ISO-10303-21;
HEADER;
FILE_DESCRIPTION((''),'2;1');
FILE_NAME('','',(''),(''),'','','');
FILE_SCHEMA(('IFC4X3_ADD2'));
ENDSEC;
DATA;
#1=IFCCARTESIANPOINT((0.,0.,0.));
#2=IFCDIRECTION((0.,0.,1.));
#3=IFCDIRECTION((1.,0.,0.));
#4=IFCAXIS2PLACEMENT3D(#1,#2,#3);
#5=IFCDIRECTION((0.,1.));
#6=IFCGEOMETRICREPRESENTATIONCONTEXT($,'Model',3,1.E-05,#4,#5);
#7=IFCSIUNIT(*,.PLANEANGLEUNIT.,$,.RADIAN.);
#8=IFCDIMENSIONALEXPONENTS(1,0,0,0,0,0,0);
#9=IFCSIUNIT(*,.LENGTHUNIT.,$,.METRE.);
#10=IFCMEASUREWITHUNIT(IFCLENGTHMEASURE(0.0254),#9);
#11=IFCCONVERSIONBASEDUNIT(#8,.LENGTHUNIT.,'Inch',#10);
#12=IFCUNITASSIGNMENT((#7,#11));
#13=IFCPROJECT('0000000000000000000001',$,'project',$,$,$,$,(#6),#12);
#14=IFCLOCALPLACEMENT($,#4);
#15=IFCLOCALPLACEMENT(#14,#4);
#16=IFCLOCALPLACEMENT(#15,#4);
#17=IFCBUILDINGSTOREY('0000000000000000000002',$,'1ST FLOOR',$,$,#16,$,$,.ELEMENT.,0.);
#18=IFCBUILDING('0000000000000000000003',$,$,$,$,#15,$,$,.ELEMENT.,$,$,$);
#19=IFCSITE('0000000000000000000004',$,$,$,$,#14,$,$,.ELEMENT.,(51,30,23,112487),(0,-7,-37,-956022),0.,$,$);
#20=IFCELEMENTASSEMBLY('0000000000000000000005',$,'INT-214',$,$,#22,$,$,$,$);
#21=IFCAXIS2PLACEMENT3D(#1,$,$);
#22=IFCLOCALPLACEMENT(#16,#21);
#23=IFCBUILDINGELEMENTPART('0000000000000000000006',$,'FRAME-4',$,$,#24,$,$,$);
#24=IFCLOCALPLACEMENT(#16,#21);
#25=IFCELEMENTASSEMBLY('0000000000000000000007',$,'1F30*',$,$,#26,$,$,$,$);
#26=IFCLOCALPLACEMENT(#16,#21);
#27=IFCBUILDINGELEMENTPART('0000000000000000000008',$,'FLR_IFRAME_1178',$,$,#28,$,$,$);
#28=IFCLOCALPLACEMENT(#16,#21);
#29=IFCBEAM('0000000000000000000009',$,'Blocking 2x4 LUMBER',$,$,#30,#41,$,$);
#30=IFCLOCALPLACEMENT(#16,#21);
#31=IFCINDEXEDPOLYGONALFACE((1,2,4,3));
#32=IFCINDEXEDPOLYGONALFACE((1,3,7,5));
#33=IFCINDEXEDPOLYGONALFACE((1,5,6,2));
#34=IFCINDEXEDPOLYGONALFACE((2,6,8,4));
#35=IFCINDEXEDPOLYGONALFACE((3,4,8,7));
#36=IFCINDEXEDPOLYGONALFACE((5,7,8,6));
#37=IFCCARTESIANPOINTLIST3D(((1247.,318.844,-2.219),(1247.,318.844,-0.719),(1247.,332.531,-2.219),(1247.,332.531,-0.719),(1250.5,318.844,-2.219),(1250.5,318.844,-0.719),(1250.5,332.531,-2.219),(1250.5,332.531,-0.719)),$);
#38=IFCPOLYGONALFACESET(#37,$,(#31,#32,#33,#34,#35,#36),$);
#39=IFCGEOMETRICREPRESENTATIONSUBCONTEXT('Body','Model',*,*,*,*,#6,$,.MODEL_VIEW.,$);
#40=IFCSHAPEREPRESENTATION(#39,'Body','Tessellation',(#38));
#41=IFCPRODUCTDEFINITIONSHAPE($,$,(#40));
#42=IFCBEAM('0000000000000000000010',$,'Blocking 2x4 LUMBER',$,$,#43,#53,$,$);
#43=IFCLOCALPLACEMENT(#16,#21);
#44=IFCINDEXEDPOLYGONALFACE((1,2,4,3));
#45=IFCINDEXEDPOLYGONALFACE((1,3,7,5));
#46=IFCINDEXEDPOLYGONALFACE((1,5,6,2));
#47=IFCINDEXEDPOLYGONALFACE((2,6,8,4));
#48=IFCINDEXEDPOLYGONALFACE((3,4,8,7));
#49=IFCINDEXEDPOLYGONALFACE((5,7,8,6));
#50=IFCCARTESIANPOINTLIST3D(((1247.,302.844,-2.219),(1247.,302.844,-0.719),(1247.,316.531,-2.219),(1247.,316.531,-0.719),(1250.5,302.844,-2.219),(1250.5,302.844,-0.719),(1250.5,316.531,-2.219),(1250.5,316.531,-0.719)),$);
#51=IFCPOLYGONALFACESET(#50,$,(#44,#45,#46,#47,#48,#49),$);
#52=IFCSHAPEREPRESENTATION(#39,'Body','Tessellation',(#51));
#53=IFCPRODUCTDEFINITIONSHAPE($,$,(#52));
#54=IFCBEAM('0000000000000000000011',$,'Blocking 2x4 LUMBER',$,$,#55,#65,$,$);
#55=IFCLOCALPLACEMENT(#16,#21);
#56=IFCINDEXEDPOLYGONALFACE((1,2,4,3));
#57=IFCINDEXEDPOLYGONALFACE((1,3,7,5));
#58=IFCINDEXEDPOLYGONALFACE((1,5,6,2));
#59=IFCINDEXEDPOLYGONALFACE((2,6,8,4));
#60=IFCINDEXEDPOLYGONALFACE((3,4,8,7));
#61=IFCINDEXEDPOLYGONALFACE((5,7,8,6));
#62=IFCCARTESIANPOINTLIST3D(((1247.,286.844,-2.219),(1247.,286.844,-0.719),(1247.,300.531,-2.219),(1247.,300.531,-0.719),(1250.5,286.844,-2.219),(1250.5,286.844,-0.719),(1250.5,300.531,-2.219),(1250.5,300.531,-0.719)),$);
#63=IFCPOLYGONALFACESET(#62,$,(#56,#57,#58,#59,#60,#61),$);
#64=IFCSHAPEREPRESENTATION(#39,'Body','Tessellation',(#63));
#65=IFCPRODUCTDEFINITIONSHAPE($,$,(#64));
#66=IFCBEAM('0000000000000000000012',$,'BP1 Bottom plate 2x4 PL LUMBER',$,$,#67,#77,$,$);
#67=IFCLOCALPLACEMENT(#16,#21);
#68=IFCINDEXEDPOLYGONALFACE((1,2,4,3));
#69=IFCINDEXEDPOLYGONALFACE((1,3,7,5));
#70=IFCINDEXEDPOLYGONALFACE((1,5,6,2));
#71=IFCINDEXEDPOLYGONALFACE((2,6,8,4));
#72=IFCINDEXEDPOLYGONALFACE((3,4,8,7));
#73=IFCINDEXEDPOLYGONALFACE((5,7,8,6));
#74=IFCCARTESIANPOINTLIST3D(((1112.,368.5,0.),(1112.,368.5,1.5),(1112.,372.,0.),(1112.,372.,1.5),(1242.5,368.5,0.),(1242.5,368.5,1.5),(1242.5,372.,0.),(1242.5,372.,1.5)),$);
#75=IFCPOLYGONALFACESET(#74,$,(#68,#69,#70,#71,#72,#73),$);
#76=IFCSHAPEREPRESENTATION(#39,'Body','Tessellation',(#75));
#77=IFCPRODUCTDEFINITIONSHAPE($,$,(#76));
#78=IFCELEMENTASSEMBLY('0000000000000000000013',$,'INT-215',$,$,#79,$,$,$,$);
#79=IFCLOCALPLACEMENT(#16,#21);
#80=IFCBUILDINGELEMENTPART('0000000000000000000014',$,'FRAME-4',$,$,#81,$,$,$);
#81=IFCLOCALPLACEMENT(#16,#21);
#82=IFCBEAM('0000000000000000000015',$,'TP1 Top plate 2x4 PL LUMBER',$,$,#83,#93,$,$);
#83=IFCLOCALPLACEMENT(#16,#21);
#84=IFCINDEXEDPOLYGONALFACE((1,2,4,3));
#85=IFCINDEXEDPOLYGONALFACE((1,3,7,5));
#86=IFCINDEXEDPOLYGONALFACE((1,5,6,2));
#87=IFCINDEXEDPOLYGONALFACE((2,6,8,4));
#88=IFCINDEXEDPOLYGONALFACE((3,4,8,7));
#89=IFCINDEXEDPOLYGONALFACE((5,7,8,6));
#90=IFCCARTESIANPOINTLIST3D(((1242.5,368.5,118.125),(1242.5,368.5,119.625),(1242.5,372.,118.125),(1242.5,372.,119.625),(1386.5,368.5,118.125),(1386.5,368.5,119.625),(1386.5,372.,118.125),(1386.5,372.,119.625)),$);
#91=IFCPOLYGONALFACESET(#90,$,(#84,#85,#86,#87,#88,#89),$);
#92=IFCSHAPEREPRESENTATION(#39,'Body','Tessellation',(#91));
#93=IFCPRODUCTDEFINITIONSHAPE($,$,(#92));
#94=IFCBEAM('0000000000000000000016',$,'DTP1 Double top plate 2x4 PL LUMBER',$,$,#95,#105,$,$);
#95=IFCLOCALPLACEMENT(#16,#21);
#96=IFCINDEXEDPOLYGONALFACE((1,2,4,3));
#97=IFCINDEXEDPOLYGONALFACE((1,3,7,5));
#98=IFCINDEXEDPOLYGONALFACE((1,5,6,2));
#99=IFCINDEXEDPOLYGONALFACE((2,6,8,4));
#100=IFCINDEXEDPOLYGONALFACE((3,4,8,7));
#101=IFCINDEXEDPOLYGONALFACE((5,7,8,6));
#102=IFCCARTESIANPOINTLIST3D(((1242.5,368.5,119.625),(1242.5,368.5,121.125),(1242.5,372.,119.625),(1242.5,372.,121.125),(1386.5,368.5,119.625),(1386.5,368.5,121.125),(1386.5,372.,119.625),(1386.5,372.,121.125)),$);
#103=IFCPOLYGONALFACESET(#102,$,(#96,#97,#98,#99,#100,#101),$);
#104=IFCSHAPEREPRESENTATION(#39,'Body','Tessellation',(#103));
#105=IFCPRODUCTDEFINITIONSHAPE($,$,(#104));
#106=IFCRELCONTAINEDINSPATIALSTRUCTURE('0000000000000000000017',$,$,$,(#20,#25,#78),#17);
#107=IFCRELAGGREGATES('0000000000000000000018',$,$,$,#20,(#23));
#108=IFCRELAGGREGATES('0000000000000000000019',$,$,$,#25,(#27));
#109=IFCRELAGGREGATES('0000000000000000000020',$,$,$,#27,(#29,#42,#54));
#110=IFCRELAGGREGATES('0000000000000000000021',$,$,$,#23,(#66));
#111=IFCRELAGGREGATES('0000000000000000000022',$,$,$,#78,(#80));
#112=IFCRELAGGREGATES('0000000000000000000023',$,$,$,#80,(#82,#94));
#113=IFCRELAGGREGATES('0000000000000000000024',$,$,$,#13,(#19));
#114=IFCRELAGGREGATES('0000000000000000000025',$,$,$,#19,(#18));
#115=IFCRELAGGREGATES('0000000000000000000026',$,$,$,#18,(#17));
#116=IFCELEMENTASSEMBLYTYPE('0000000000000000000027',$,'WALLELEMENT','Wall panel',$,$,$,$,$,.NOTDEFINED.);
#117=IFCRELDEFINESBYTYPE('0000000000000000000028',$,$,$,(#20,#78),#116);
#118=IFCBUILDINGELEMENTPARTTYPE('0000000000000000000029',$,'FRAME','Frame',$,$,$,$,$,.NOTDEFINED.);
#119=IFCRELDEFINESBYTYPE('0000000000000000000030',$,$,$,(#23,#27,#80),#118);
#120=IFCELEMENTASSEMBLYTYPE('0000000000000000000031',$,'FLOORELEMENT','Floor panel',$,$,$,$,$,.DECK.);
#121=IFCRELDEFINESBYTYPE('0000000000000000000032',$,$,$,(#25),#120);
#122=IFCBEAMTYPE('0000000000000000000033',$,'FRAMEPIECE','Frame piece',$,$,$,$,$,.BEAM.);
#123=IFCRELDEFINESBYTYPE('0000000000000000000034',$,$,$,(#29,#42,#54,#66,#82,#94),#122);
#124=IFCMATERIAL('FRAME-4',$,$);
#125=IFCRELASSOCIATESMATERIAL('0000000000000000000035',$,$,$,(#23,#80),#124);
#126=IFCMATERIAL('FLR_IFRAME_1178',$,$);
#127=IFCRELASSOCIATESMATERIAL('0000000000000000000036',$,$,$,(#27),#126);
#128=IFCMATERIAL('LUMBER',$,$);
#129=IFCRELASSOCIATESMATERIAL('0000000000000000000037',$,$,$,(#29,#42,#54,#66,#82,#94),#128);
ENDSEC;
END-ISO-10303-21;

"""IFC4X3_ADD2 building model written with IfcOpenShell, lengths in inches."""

from ifc_helpers import new_model, entity, si_unit, converted_unit, direction, frame, origin_with_axes, origin_2d_with_axis, place, context, subcontext, project, spatial, rectangle, extrude, material, type_object, element, aggregate, save


model = new_model("IFC4X3_ADD2")

# Units and contexts
model_context = context("Model", 3, precision=1e-05, world=origin_with_axes(), true_north=direction((0.0, 1.0)))
body_context = subcontext(model_context, "Body", "Model", "MODEL_VIEW")
ifc_project = project(units=[si_unit("PLANEANGLEUNIT", "RADIAN"), converted_unit("LENGTHUNIT", "Inch", entity("IfcLengthMeasure", 0.0254), si_unit("LENGTHUNIT", "METRE"), dimensions=[1, 0, 0, 0, 0, 0, 0])], contexts=[model_context])

# Site, building, storey
site_placement = place(None, origin_with_axes())
site = spatial("IfcSite", under=ifc_project, at=site_placement, CompositionType="ELEMENT", RefLatitude=(51, 30, 23, 112487), RefLongitude=(0, -7, -37, -956022), RefElevation=0.0)
building_placement = place(site_placement, origin_with_axes())
building = spatial("IfcBuilding", under=site, at=building_placement, CompositionType="ELEMENT")
storey_placement = place(building_placement, origin_with_axes())
storey = spatial("IfcBuildingStorey", under=building, at=storey_placement, Name="1ST FLOOR", CompositionType="ELEMENT", Elevation=0.0)

# Element assembly, building element part
element_assembly_type_1 = type_object("IfcElementAssemblyType", Name="WALLELEMENT", Description="Wall panel", PredefinedType="NOTDEFINED")
assembly_1_placement = place(storey_placement, origin_with_axes())
assembly_1 = element("IfcElementAssembly", 1, at=assembly_1_placement, inside=storey, type_object=element_assembly_type_1, Name="INT-214")
ifc_material_1 = material(Name="FRAME-4")
building_element_part_type = type_object("IfcBuildingElementPartType", Name="FRAME", Description="Frame", PredefinedType="NOTDEFINED")
building_element_part_1_placement = place(storey_placement, origin_with_axes())
building_element_part_1 = element("IfcBuildingElementPart", 2, at=building_element_part_1_placement, type_object=building_element_part_type, material=ifc_material_1, Name="FRAME-4")
aggregate(assembly_1, [building_element_part_1])
ifc_material_2 = material(Name="LUMBER")

# Element assembly, building element part, beams
element_assembly_type_2 = type_object("IfcElementAssemblyType", Name="FLOORELEMENT", Description="Floor panel", PredefinedType="DECK")
ifc_material_3 = material(Name="FLR_IFRAME_1178")
beam_type = type_object("IfcBeamType", Name="FRAMEPIECE", Description="Frame piece", PredefinedType="BEAM")
assembly_2_placement = place(storey_placement, origin_with_axes())
assembly_2 = element("IfcElementAssembly", 3, at=assembly_2_placement, inside=storey, type_object=element_assembly_type_2, Name="1F30*")
building_element_part_2_placement = place(storey_placement, origin_with_axes())
building_element_part_2 = element("IfcBuildingElementPart", 4, at=building_element_part_2_placement, type_object=building_element_part_type, material=ifc_material_3, Name="FLR_IFRAME_1178")
aggregate(assembly_2, [building_element_part_2])
beam_1_placement = place(storey_placement, frame((1248.75, 332.531, -1.469), z_axis=(0.0, -1.0, 0.0), x_axis=(0.0, 0.0, 1.0)))
beam_1 = element("IfcBeam", 5, at=beam_1_placement, type_object=beam_type, material=ifc_material_2, Name="Blocking 2x4 LUMBER", context=body_context, shape_type="SweptSolid", body=[
    extrude(rectangle(XDim=1.5, YDim=3.5, at=origin_2d_with_axis()), origin_with_axes(), (0.0, 0.0, 1.0), 13.688),
])
beam_2_placement = place(storey_placement, frame((1248.75, 316.531, -1.469), z_axis=(0.0, -1.0, 0.0), x_axis=(0.0, 0.0, 1.0)))
beam_2 = element("IfcBeam", 6, at=beam_2_placement, type_object=beam_type, material=ifc_material_2, Name="Blocking 2x4 LUMBER", context=body_context, shape_type="SweptSolid", body=[
    extrude(rectangle(XDim=1.5, YDim=3.5, at=origin_2d_with_axis()), origin_with_axes(), (0.0, 0.0, 1.0), 13.688),
])
beam_3_placement = place(storey_placement, frame((1248.75, 300.531, -1.469), z_axis=(0.0, -1.0, 0.0), x_axis=(0.0, 0.0, 1.0)))
beam_3 = element("IfcBeam", 7, at=beam_3_placement, type_object=beam_type, material=ifc_material_2, Name="Blocking 2x4 LUMBER", context=body_context, shape_type="SweptSolid", body=[
    extrude(rectangle(XDim=1.5, YDim=3.5, at=origin_2d_with_axis()), origin_with_axes(), (0.0, 0.0, 1.0), 13.688),
])
aggregate(building_element_part_2, [beam_1, beam_2, beam_3])

# Beam
beam_4_placement = place(storey_placement, frame((1242.5, 370.25, 0.75), z_axis=(-1.0, 0.0, 0.0), x_axis=(0.0, 0.0, 1.0)))
beam_4 = element("IfcBeam", 8, at=beam_4_placement, type_object=beam_type, material=ifc_material_2, Name="BP1 Bottom plate 2x4 PL LUMBER", context=body_context, shape_type="SweptSolid", body=[
    extrude(rectangle(XDim=1.5, YDim=3.5, at=origin_2d_with_axis()), origin_with_axes(), (0.0, 0.0, 1.0), 130.5),
])
aggregate(building_element_part_1, [beam_4])

# Element assembly, building element part, beams
assembly_3_placement = place(storey_placement, origin_with_axes())
assembly_3 = element("IfcElementAssembly", 9, at=assembly_3_placement, inside=storey, type_object=element_assembly_type_1, Name="INT-215")
building_element_part_3_placement = place(storey_placement, origin_with_axes())
building_element_part_3 = element("IfcBuildingElementPart", 10, at=building_element_part_3_placement, type_object=building_element_part_type, material=ifc_material_1, Name="FRAME-4")
aggregate(assembly_3, [building_element_part_3])
beam_5_placement = place(storey_placement, frame((1242.5, 370.25, 118.875), z_axis=(1.0, 0.0, 0.0), x_axis=(0.0, 0.0, -1.0)))
beam_5 = element("IfcBeam", 11, at=beam_5_placement, type_object=beam_type, material=ifc_material_2, Name="TP1 Top plate 2x4 PL LUMBER", context=body_context, shape_type="SweptSolid", body=[
    extrude(rectangle(XDim=1.5, YDim=3.5, at=origin_2d_with_axis()), origin_with_axes(), (0.0, 0.0, 1.0), 144.0),
])
beam_6_placement = place(storey_placement, frame((1242.5, 370.25, 120.375), z_axis=(1.0, 0.0, 0.0), x_axis=(0.0, 0.0, -1.0)))
beam_6 = element("IfcBeam", 12, at=beam_6_placement, type_object=beam_type, material=ifc_material_2, Name="DTP1 Double top plate 2x4 PL LUMBER", context=body_context, shape_type="SweptSolid", body=[
    extrude(rectangle(XDim=1.5, YDim=3.5, at=origin_2d_with_axis()), origin_with_axes(), (0.0, 0.0, 1.0), 144.0),
])
aggregate(building_element_part_3, [beam_5, beam_6])

save(model, "model.ifc")
